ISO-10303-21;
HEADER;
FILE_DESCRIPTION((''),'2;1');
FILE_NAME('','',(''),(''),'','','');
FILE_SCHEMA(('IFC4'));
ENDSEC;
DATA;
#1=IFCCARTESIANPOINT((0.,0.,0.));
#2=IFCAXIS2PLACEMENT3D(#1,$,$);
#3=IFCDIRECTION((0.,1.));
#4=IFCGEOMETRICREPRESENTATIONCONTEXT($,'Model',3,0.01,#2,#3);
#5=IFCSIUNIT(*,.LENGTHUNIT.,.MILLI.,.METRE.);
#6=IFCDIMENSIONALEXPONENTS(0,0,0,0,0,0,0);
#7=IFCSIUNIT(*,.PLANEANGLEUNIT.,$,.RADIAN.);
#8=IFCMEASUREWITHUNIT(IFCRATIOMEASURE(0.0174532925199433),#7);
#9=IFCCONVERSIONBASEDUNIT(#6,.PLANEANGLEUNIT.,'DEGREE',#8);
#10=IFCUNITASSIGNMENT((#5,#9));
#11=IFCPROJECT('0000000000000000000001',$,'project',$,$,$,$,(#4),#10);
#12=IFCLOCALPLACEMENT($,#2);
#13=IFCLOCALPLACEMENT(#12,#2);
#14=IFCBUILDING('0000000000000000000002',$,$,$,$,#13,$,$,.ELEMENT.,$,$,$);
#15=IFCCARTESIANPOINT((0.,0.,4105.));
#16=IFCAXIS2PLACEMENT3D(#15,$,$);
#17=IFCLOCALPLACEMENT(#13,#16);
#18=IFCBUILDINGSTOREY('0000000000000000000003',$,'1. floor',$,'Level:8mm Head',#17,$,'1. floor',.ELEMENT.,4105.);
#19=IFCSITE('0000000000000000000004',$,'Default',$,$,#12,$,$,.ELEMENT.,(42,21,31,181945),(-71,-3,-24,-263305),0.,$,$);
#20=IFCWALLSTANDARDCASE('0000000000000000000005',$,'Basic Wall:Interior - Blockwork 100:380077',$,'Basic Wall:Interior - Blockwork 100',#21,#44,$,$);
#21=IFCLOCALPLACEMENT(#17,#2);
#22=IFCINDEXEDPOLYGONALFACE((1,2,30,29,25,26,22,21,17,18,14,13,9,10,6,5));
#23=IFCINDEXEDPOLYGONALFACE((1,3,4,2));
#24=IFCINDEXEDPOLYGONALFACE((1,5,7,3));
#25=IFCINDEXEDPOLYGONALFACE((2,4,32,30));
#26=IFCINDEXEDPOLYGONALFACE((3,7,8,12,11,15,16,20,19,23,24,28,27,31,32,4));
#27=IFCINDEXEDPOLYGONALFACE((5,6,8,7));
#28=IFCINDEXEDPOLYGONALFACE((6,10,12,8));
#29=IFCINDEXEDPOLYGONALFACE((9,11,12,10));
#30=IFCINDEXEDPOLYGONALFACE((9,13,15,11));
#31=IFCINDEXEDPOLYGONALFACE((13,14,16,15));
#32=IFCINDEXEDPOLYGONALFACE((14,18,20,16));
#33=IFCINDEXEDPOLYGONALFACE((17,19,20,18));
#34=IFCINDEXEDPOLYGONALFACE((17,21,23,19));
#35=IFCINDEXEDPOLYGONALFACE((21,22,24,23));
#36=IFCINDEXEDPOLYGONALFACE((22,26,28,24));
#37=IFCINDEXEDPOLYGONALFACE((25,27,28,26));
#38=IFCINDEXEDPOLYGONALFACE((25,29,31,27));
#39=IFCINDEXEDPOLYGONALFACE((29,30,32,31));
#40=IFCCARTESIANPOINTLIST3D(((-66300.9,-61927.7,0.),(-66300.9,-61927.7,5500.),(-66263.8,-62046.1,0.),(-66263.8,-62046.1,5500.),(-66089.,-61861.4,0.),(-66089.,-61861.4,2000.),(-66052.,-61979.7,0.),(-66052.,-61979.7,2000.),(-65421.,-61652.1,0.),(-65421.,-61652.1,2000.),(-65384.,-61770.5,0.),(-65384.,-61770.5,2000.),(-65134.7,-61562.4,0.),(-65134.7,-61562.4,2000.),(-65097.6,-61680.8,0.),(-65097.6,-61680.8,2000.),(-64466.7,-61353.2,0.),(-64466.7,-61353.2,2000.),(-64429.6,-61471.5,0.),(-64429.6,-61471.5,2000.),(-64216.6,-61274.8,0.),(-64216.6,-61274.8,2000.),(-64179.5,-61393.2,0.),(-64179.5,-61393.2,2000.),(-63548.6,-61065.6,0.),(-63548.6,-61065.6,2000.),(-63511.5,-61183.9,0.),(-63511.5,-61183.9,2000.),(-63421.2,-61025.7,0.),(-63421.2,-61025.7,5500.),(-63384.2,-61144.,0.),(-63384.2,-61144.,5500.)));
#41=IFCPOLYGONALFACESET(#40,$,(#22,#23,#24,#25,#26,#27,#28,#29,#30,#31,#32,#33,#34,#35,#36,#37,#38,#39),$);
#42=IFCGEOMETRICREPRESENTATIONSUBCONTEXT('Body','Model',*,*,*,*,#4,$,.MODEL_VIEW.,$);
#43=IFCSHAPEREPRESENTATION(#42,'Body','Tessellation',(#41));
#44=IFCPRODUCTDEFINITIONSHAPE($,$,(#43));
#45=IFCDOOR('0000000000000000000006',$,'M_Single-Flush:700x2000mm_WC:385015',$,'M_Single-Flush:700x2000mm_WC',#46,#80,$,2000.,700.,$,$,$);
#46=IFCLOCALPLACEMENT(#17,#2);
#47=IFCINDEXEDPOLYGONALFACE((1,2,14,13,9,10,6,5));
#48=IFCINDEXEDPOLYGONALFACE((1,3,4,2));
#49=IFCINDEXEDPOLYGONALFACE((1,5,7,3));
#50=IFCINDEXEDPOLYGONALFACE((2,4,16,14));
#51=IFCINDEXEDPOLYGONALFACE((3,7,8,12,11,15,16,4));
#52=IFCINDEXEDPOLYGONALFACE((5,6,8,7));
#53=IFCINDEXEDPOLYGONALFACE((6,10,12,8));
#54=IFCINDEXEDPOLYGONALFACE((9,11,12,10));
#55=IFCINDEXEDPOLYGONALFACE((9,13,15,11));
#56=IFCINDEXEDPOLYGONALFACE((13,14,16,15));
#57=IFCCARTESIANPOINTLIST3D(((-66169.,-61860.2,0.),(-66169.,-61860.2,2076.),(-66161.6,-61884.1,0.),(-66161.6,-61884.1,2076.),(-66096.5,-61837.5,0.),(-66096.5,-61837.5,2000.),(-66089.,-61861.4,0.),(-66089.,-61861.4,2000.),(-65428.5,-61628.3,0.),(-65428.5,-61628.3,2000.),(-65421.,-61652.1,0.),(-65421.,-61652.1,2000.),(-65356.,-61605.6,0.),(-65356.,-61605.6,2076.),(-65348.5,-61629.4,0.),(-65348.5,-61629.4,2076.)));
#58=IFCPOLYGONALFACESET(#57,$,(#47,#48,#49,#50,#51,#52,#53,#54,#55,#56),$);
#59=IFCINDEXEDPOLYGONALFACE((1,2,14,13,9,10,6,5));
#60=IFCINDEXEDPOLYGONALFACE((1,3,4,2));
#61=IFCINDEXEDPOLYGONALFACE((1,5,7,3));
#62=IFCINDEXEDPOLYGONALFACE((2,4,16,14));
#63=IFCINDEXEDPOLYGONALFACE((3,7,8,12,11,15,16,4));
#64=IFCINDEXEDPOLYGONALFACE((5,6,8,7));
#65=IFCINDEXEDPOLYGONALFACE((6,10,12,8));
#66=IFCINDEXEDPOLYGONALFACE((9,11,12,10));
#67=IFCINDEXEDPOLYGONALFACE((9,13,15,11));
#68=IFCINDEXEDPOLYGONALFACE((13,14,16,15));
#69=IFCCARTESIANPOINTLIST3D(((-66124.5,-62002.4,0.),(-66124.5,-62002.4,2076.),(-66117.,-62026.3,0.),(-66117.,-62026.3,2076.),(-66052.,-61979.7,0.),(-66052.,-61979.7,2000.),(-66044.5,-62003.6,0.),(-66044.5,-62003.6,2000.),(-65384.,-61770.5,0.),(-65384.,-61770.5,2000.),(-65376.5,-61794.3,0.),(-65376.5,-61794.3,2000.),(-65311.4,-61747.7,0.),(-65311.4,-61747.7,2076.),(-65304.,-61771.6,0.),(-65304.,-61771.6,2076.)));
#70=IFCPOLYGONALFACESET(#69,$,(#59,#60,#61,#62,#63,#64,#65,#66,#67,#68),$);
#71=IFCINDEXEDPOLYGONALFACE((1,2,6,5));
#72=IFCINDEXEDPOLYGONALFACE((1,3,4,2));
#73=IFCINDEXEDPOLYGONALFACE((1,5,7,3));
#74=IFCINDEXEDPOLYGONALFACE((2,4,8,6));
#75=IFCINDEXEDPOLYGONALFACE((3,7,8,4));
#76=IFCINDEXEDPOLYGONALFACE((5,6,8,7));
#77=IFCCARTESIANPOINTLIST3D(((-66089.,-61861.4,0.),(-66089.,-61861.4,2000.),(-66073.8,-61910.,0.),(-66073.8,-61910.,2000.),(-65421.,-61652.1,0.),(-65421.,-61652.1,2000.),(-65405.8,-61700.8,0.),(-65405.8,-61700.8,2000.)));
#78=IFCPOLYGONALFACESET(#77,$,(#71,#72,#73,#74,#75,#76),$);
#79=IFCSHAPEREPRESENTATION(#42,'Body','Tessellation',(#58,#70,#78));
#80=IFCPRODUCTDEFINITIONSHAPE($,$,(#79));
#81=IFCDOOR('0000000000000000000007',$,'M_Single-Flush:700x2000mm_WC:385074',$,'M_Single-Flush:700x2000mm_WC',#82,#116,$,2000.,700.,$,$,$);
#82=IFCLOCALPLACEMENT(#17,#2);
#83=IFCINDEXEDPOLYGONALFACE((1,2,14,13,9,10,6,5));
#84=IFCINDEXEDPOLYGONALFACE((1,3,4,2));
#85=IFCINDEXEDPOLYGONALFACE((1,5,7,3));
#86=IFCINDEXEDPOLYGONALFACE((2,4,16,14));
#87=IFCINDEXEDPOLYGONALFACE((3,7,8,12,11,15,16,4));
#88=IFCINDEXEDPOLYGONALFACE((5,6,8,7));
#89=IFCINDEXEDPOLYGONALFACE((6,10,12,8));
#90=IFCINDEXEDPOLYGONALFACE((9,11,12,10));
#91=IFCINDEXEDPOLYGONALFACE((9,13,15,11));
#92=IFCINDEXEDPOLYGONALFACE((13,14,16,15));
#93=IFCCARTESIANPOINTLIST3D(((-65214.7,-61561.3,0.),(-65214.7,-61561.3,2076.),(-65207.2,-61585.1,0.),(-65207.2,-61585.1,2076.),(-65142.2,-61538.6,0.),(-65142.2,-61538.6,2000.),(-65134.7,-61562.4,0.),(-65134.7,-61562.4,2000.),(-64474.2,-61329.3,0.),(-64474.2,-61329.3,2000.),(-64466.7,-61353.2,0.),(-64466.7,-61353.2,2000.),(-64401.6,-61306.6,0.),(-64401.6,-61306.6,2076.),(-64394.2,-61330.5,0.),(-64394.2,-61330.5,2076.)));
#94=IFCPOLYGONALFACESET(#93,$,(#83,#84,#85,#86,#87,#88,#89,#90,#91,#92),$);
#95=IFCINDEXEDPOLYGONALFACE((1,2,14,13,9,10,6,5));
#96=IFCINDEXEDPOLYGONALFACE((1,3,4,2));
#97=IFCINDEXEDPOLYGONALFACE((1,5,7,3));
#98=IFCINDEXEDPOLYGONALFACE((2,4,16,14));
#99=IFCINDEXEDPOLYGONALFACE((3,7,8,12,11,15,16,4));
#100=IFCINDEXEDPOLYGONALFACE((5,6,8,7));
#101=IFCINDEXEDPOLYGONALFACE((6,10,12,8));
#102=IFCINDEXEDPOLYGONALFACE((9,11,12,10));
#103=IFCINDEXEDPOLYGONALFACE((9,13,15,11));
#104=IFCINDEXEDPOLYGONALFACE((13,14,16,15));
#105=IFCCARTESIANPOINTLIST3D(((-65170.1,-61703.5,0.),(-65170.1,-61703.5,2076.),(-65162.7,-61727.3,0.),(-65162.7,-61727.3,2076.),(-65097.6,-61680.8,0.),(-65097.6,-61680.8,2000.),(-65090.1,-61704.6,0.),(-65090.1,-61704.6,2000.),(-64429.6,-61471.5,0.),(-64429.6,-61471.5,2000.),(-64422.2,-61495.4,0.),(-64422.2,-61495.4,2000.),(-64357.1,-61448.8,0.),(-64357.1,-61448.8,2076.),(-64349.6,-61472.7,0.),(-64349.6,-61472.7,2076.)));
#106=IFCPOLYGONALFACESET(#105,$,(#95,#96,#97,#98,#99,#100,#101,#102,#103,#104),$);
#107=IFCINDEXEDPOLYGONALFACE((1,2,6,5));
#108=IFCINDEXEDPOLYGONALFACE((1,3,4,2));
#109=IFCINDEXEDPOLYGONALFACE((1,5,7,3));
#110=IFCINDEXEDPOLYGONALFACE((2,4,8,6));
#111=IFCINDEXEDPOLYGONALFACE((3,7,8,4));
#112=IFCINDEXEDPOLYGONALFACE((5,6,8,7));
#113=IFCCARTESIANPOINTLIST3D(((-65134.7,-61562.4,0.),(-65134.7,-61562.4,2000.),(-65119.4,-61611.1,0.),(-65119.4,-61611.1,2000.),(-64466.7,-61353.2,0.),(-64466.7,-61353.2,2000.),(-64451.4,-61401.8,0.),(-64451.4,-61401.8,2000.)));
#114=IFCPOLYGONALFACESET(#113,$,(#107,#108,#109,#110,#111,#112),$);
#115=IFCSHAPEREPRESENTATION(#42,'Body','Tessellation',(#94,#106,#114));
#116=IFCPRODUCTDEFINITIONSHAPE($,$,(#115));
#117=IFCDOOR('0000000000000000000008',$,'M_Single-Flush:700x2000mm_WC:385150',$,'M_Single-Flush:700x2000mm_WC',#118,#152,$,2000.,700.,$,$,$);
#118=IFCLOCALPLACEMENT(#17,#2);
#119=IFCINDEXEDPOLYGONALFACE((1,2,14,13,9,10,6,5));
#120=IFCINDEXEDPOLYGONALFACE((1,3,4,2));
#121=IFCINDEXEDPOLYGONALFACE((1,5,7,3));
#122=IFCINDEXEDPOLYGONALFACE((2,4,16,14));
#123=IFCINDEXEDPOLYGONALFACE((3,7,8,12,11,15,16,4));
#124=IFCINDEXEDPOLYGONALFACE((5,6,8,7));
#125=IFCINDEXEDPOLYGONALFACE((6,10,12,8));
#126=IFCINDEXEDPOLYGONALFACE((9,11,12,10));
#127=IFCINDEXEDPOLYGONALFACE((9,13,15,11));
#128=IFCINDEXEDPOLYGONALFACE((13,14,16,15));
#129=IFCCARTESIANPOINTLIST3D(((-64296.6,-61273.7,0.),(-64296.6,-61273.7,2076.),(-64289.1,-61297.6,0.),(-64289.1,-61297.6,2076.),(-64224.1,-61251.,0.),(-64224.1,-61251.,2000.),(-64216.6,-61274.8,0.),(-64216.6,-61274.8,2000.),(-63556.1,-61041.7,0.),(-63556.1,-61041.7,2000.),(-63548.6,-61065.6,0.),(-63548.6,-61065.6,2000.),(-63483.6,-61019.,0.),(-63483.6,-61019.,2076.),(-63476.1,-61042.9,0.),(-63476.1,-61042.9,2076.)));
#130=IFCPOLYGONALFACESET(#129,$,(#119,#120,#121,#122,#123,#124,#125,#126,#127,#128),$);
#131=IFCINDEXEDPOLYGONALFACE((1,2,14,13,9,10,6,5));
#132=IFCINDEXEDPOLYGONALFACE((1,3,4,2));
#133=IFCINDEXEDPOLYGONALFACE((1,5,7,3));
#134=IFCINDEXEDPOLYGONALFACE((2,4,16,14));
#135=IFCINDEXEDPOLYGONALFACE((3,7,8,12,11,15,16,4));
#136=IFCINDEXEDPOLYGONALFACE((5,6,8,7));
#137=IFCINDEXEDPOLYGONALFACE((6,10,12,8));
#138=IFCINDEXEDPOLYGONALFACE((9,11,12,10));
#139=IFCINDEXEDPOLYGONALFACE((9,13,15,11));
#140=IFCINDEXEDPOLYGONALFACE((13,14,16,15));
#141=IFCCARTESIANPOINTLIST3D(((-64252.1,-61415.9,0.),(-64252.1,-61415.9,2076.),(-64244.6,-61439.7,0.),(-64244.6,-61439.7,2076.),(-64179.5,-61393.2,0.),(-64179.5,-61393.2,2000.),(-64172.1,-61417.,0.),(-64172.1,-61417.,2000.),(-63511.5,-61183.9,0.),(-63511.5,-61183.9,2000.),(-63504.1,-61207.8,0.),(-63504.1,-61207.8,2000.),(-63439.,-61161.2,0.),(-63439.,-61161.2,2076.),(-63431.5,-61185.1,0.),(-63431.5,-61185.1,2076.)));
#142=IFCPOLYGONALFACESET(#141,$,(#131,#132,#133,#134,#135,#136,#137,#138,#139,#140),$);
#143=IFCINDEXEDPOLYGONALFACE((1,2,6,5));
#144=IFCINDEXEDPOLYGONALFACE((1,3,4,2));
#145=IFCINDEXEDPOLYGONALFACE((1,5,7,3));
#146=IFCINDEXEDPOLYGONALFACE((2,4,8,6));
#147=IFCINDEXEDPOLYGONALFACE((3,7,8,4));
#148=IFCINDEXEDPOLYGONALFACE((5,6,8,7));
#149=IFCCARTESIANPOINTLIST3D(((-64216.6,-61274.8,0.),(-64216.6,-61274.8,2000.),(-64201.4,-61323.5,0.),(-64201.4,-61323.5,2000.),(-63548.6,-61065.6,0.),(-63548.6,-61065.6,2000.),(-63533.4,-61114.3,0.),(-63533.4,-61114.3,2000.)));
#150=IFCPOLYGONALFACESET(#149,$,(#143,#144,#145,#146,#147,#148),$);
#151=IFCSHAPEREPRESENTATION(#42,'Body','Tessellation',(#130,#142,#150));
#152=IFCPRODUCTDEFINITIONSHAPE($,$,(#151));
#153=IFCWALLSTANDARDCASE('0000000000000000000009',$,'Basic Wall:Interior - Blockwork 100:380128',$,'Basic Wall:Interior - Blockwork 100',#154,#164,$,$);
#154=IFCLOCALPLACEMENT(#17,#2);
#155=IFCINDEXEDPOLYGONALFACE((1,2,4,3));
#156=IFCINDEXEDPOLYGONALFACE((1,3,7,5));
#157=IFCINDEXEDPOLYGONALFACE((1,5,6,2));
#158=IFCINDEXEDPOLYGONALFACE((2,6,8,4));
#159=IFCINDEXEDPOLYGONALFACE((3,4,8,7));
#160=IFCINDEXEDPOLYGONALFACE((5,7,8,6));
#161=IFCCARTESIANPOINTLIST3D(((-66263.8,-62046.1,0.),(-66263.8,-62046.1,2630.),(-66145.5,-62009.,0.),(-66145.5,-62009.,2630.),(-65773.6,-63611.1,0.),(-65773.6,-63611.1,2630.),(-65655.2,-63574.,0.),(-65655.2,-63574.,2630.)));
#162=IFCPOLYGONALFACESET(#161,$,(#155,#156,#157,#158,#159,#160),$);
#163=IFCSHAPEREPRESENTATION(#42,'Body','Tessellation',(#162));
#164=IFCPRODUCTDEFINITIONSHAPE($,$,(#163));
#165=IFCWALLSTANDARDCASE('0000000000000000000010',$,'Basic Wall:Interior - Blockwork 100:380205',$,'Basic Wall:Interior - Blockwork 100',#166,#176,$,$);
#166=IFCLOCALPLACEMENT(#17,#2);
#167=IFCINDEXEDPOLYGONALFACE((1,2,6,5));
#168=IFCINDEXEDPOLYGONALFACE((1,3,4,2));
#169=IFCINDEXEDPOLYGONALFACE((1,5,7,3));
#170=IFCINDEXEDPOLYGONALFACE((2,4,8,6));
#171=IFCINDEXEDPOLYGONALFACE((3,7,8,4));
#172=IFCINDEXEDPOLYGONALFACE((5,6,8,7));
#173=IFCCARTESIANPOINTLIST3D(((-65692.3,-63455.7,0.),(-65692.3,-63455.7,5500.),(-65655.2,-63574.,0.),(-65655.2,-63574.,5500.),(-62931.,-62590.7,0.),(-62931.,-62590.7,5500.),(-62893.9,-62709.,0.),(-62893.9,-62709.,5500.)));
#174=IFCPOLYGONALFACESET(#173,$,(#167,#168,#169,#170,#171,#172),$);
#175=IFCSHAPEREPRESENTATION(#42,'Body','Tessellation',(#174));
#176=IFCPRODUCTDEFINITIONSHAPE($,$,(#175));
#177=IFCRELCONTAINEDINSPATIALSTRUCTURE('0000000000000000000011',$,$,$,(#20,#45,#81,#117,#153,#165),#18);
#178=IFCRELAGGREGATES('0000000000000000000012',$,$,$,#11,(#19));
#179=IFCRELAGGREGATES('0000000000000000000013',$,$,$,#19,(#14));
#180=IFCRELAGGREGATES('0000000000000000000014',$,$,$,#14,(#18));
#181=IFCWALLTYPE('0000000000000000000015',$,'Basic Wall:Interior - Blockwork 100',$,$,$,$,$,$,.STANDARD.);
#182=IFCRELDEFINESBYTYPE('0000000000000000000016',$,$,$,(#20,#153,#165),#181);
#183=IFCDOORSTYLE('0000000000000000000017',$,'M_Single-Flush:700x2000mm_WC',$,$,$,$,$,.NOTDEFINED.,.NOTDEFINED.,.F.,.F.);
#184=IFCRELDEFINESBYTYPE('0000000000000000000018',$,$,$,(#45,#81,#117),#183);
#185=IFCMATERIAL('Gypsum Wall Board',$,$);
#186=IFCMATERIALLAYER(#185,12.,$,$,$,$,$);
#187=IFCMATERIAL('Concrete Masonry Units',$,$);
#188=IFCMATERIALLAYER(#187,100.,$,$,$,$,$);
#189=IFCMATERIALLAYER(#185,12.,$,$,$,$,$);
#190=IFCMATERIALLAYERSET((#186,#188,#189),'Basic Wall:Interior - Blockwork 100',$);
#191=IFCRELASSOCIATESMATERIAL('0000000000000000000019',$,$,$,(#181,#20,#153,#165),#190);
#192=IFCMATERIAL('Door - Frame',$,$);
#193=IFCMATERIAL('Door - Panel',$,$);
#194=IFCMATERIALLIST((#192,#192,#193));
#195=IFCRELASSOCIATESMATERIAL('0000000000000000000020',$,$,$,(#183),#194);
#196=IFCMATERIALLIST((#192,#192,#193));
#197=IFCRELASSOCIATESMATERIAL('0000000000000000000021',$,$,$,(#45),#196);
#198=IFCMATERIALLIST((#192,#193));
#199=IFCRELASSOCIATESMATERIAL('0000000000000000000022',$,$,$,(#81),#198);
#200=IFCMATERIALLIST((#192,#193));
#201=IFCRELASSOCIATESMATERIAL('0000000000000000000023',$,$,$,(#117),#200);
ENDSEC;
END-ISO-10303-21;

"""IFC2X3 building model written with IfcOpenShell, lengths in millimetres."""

from ifc_helpers import new_model, entity, si_unit, converted_unit, direction, frame, frame_2d, origin, origin_2d_with_axis, place, context, subcontext, project, spatial, polyline, rectangle, outline, extrude, source, transform, mapped, material, material_list, layer, layer_set, layer_usage, type_object, type_shapes, element, fill, save


model = new_model("IFC2X3")

# Units and contexts
model_context = context("Model", 3, precision=0.01, world=origin(), true_north=direction((0.0, 1.0)))
body_context = subcontext(model_context, "Body", "Model", "MODEL_VIEW")
ifc_project = project(units=[si_unit("LENGTHUNIT", "METRE", prefix="MILLI"), converted_unit("PLANEANGLEUNIT", "DEGREE", entity("IfcRatioMeasure", 0.0174532925199433), si_unit("PLANEANGLEUNIT", "RADIAN"), dimensions=[0, 0, 0, 0, 0, 0, 0])], contexts=[model_context])

# Site, building, storey
site_placement = place(None, origin())
site = spatial("IfcSite", under=ifc_project, at=site_placement, Name="Default", CompositionType="ELEMENT", RefLatitude=(42, 21, 31, 181945), RefLongitude=(-71, -3, -24, -263305), RefElevation=0.0)
building_placement = place(site_placement, origin())
building = spatial("IfcBuilding", under=site, at=building_placement, CompositionType="ELEMENT")
storey_placement = place(building_placement, frame((0.0, 0.0, 4105.0)))
storey = spatial("IfcBuildingStorey", under=building, at=storey_placement, Name="1. floor", ObjectType="Level:8mm Head", LongName="1. floor", CompositionType="ELEMENT", Elevation=4105.0)

# Shared definitions
ifc_material_1 = material(Name="Gypsum Wall Board")

# Shared definitions
ifc_layer_1 = layer(ifc_material_1, 12.0)
ifc_material_2 = material(Name="Concrete Masonry Units")
ifc_layer_2 = layer(ifc_material_2, 100.0)
ifc_layer_3 = layer(ifc_material_1, 12.0)
ifc_layer_set_1 = layer_set([ifc_layer_1, ifc_layer_2, ifc_layer_3], Name="Basic Wall:Interior - Blockwork 100")
wall_type_1 = type_object("IfcWallType", Name="Basic Wall:Interior - Blockwork 100", PredefinedType="STANDARD", material=ifc_layer_set_1)
ifc_material_3 = material(Name="Door - Frame")
ifc_material_4 = material(Name="Door - Panel")

# Wall, openings, doors
ifc_layer_usage_1 = layer_usage(ifc_layer_set_1, "AXIS2", "NEGATIVE", 62.0)
wall_1_placement = place(storey_placement, frame((-63402.7, -61084.9, 0.0), z_axis=(0.0, 0.0, 1.0), x_axis=(-0.954277, -0.298924, 0.0)))
wall_1 = element("IfcWallStandardCase", 1, at=wall_1_placement, inside=storey, type_object=wall_type_1, material=ifc_layer_usage_1, Name="Basic Wall:Interior - Blockwork 100:380077", ObjectType="Basic Wall:Interior - Blockwork 100", context=body_context, shape_type="SweptSolid", body=[
    extrude(rectangle(XDim=3017.6, YDim=124.0, at=frame_2d((1508.8, 0.0), x_axis=(-1.0, 0.0))), origin(), (0.0, 0.0, 1.0), 5500.0),
])
opening_1_placement = place(wall_1_placement, frame((2795.6, 62.0, 0.0)))
opening_1 = element("IfcOpeningElement", 2, at=opening_1_placement, cuts=wall_1, ObjectType="Opening", context=body_context, shape_type="SweptSolid", body=[
    extrude(rectangle(XDim=700.0, YDim=2000.0, at=frame_2d((1000.0, 350.0), x_axis=(0.0, 1.0))), frame((0.0, 0.0, 0.0), z_axis=(0.0, -1.0, 0.0), x_axis=(0.0, 0.0, 1.0)), (0.0, 0.0, 1.0), 124.0),
])
opening_2_placement = place(wall_1_placement, frame((1795.5, 62.0, 0.0)))
opening_2 = element("IfcOpeningElement", 3, at=opening_2_placement, cuts=wall_1, ObjectType="Opening", context=body_context, shape_type="SweptSolid", body=[
    extrude(rectangle(XDim=700.0, YDim=2000.0, at=frame_2d((1000.0, 350.0), x_axis=(0.0, 1.0))), frame((0.0, 0.0, 0.0), z_axis=(0.0, -1.0, 0.0), x_axis=(0.0, 0.0, 1.0)), (0.0, 0.0, 1.0), 124.0),
])
opening_3_placement = place(wall_1_placement, frame((833.5, 62.0, 0.0)))
opening_3 = element("IfcOpeningElement", 4, at=opening_3_placement, cuts=wall_1, ObjectType="Opening", context=body_context, shape_type="SweptSolid", body=[
    extrude(rectangle(XDim=700.0, YDim=2000.0, at=frame_2d((1000.0, 350.0), x_axis=(0.0, 1.0))), frame((0.0, 0.0, 0.0), z_axis=(0.0, -1.0, 0.0), x_axis=(0.0, 0.0, 1.0)), (0.0, 0.0, 1.0), 124.0),
])
ifc_material_list_1 = material_list([ifc_material_3, ifc_material_3, ifc_material_4])
ifc_material_list_2 = material_list([ifc_material_3, ifc_material_3, ifc_material_4])
door_style_1 = type_object("IfcDoorStyle", Name="M_Single-Flush:700x2000mm_WC", ConstructionType="NOTDEFINED", OperationType="NOTDEFINED", ParameterTakesPrecedence=False, Sizeable=False, material=ifc_material_list_2)
shared_shape_1 = source(origin(), body_context, "Body", "SweptSolid", [
    extrude(outline(polyline([(-426.0, -1057.0), (426.0, -1057.0), (426.0, 1019.0), (350.0, 1019.0), (350.0, -981.0), (-350.0, -981.0), (-350.0, 1019.0), (-426.0, 1019.0), (-426.0, -1057.0)])), frame((350.0, 124.0, 1019.0), z_axis=(0.0, 1.0, 0.0), x_axis=(1.0, 0.0, 0.0)), (0.0, 0.0, 1.0), 25.0),
    extrude(outline(polyline([(-1057.0, -426.0), (1019.0, -426.0), (1019.0, -350.0), (-981.0, -350.0), (-981.0, 350.0), (1019.0, 350.0), (1019.0, 426.0), (-1057.0, 426.0), (-1057.0, -426.0)])), frame((350.0, -25.0, 1019.0), z_axis=(0.0, 1.0, 0.0), x_axis=(0.0, 0.0, -1.0)), (0.0, 0.0, 1.0), 25.0),
    extrude(rectangle(XDim=51.0, YDim=700.0, at=origin_2d_with_axis()), frame((350.0, 98.5, 0.0), z_axis=(0.0, 0.0, 1.0), x_axis=(0.0, 1.0, 0.0)), (0.0, 0.0, 1.0), 2000.0),
])
type_shapes(door_style_1, [shared_shape_1])
door_1_placement = place(opening_1_placement, frame((0.0, 0.0, 0.0), z_axis=(0.0, 0.0, 1.0), x_axis=(-1.0, 0.0, 0.0)))
door_1 = element("IfcDoor", 5, at=door_1_placement, inside=storey, type_object=door_style_1, material=ifc_material_list_1, Name="M_Single-Flush:700x2000mm_WC:385015", ObjectType="M_Single-Flush:700x2000mm_WC", OverallHeight=2000.0, OverallWidth=700.0, context=body_context, shape_type="MappedRepresentation", body=[
    mapped(shared_shape_1, transform((0.0, 0.0, 0.0), scale=1.0)),
])
fill(opening_1, door_1)
ifc_material_list_3 = material_list([ifc_material_3, ifc_material_4])
door_2_placement = place(opening_2_placement, frame((0.0, 0.0, 0.0), z_axis=(0.0, 0.0, 1.0), x_axis=(-1.0, 0.0, 0.0)))
door_2 = element("IfcDoor", 6, at=door_2_placement, inside=storey, type_object=door_style_1, material=ifc_material_list_3, Name="M_Single-Flush:700x2000mm_WC:385074", ObjectType="M_Single-Flush:700x2000mm_WC", OverallHeight=2000.0, OverallWidth=700.0, context=body_context, shape_type="MappedRepresentation", body=[
    mapped(shared_shape_1, transform((0.0, 0.0, 0.0), scale=1.0)),
])
fill(opening_2, door_2)
ifc_material_list_4 = material_list([ifc_material_3, ifc_material_4])
door_3_placement = place(opening_3_placement, frame((0.0, 0.0, 0.0), z_axis=(0.0, 0.0, 1.0), x_axis=(-1.0, 0.0, 0.0)))
door_3 = element("IfcDoor", 7, at=door_3_placement, inside=storey, type_object=door_style_1, material=ifc_material_list_4, Name="M_Single-Flush:700x2000mm_WC:385150", ObjectType="M_Single-Flush:700x2000mm_WC", OverallHeight=2000.0, OverallWidth=700.0, context=body_context, shape_type="MappedRepresentation", body=[
    mapped(shared_shape_1, transform((0.0, 0.0, 0.0), scale=1.0)),
])
fill(opening_3, door_3)

# Walls
ifc_layer_usage_2 = layer_usage(ifc_layer_set_1, "AXIS2", "NEGATIVE", 62.0)
wall_2_placement = place(storey_placement, frame((-66204.6, -62027.5, 0.0), z_axis=(0.0, 0.0, 1.0), x_axis=(0.298924, -0.954277, 0.0)))
element("IfcWallStandardCase", 8, at=wall_2_placement, inside=storey, type_object=wall_type_1, material=ifc_layer_usage_2, Name="Basic Wall:Interior - Blockwork 100:380128", ObjectType="Basic Wall:Interior - Blockwork 100", context=body_context, shape_type="SweptSolid", body=[
    extrude(rectangle(XDim=1640.0, YDim=124.0, at=frame_2d((820.0, 0.0), x_axis=(-1.0, 0.0))), origin(), (0.0, 0.0, 1.0), 2630.0),
])
ifc_layer_usage_3 = layer_usage(ifc_layer_set_1, "AXIS2", "NEGATIVE", 62.0)
wall_3_placement = place(storey_placement, frame((-62912.5, -62649.9, 0.0), z_axis=(0.0, 0.0, 1.0), x_axis=(-0.954277, -0.298924, 0.0)))
element("IfcWallStandardCase", 9, at=wall_3_placement, inside=storey, type_object=wall_type_1, material=ifc_layer_usage_3, Name="Basic Wall:Interior - Blockwork 100:380205", ObjectType="Basic Wall:Interior - Blockwork 100", context=body_context, shape_type="SweptSolid", body=[
    extrude(rectangle(XDim=2893.6, YDim=124.0, at=frame_2d((1446.8, 0.0), x_axis=(-1.0, 0.0))), origin(), (0.0, 0.0, 1.0), 5500.0),
])

save(model, "model.ifc")
